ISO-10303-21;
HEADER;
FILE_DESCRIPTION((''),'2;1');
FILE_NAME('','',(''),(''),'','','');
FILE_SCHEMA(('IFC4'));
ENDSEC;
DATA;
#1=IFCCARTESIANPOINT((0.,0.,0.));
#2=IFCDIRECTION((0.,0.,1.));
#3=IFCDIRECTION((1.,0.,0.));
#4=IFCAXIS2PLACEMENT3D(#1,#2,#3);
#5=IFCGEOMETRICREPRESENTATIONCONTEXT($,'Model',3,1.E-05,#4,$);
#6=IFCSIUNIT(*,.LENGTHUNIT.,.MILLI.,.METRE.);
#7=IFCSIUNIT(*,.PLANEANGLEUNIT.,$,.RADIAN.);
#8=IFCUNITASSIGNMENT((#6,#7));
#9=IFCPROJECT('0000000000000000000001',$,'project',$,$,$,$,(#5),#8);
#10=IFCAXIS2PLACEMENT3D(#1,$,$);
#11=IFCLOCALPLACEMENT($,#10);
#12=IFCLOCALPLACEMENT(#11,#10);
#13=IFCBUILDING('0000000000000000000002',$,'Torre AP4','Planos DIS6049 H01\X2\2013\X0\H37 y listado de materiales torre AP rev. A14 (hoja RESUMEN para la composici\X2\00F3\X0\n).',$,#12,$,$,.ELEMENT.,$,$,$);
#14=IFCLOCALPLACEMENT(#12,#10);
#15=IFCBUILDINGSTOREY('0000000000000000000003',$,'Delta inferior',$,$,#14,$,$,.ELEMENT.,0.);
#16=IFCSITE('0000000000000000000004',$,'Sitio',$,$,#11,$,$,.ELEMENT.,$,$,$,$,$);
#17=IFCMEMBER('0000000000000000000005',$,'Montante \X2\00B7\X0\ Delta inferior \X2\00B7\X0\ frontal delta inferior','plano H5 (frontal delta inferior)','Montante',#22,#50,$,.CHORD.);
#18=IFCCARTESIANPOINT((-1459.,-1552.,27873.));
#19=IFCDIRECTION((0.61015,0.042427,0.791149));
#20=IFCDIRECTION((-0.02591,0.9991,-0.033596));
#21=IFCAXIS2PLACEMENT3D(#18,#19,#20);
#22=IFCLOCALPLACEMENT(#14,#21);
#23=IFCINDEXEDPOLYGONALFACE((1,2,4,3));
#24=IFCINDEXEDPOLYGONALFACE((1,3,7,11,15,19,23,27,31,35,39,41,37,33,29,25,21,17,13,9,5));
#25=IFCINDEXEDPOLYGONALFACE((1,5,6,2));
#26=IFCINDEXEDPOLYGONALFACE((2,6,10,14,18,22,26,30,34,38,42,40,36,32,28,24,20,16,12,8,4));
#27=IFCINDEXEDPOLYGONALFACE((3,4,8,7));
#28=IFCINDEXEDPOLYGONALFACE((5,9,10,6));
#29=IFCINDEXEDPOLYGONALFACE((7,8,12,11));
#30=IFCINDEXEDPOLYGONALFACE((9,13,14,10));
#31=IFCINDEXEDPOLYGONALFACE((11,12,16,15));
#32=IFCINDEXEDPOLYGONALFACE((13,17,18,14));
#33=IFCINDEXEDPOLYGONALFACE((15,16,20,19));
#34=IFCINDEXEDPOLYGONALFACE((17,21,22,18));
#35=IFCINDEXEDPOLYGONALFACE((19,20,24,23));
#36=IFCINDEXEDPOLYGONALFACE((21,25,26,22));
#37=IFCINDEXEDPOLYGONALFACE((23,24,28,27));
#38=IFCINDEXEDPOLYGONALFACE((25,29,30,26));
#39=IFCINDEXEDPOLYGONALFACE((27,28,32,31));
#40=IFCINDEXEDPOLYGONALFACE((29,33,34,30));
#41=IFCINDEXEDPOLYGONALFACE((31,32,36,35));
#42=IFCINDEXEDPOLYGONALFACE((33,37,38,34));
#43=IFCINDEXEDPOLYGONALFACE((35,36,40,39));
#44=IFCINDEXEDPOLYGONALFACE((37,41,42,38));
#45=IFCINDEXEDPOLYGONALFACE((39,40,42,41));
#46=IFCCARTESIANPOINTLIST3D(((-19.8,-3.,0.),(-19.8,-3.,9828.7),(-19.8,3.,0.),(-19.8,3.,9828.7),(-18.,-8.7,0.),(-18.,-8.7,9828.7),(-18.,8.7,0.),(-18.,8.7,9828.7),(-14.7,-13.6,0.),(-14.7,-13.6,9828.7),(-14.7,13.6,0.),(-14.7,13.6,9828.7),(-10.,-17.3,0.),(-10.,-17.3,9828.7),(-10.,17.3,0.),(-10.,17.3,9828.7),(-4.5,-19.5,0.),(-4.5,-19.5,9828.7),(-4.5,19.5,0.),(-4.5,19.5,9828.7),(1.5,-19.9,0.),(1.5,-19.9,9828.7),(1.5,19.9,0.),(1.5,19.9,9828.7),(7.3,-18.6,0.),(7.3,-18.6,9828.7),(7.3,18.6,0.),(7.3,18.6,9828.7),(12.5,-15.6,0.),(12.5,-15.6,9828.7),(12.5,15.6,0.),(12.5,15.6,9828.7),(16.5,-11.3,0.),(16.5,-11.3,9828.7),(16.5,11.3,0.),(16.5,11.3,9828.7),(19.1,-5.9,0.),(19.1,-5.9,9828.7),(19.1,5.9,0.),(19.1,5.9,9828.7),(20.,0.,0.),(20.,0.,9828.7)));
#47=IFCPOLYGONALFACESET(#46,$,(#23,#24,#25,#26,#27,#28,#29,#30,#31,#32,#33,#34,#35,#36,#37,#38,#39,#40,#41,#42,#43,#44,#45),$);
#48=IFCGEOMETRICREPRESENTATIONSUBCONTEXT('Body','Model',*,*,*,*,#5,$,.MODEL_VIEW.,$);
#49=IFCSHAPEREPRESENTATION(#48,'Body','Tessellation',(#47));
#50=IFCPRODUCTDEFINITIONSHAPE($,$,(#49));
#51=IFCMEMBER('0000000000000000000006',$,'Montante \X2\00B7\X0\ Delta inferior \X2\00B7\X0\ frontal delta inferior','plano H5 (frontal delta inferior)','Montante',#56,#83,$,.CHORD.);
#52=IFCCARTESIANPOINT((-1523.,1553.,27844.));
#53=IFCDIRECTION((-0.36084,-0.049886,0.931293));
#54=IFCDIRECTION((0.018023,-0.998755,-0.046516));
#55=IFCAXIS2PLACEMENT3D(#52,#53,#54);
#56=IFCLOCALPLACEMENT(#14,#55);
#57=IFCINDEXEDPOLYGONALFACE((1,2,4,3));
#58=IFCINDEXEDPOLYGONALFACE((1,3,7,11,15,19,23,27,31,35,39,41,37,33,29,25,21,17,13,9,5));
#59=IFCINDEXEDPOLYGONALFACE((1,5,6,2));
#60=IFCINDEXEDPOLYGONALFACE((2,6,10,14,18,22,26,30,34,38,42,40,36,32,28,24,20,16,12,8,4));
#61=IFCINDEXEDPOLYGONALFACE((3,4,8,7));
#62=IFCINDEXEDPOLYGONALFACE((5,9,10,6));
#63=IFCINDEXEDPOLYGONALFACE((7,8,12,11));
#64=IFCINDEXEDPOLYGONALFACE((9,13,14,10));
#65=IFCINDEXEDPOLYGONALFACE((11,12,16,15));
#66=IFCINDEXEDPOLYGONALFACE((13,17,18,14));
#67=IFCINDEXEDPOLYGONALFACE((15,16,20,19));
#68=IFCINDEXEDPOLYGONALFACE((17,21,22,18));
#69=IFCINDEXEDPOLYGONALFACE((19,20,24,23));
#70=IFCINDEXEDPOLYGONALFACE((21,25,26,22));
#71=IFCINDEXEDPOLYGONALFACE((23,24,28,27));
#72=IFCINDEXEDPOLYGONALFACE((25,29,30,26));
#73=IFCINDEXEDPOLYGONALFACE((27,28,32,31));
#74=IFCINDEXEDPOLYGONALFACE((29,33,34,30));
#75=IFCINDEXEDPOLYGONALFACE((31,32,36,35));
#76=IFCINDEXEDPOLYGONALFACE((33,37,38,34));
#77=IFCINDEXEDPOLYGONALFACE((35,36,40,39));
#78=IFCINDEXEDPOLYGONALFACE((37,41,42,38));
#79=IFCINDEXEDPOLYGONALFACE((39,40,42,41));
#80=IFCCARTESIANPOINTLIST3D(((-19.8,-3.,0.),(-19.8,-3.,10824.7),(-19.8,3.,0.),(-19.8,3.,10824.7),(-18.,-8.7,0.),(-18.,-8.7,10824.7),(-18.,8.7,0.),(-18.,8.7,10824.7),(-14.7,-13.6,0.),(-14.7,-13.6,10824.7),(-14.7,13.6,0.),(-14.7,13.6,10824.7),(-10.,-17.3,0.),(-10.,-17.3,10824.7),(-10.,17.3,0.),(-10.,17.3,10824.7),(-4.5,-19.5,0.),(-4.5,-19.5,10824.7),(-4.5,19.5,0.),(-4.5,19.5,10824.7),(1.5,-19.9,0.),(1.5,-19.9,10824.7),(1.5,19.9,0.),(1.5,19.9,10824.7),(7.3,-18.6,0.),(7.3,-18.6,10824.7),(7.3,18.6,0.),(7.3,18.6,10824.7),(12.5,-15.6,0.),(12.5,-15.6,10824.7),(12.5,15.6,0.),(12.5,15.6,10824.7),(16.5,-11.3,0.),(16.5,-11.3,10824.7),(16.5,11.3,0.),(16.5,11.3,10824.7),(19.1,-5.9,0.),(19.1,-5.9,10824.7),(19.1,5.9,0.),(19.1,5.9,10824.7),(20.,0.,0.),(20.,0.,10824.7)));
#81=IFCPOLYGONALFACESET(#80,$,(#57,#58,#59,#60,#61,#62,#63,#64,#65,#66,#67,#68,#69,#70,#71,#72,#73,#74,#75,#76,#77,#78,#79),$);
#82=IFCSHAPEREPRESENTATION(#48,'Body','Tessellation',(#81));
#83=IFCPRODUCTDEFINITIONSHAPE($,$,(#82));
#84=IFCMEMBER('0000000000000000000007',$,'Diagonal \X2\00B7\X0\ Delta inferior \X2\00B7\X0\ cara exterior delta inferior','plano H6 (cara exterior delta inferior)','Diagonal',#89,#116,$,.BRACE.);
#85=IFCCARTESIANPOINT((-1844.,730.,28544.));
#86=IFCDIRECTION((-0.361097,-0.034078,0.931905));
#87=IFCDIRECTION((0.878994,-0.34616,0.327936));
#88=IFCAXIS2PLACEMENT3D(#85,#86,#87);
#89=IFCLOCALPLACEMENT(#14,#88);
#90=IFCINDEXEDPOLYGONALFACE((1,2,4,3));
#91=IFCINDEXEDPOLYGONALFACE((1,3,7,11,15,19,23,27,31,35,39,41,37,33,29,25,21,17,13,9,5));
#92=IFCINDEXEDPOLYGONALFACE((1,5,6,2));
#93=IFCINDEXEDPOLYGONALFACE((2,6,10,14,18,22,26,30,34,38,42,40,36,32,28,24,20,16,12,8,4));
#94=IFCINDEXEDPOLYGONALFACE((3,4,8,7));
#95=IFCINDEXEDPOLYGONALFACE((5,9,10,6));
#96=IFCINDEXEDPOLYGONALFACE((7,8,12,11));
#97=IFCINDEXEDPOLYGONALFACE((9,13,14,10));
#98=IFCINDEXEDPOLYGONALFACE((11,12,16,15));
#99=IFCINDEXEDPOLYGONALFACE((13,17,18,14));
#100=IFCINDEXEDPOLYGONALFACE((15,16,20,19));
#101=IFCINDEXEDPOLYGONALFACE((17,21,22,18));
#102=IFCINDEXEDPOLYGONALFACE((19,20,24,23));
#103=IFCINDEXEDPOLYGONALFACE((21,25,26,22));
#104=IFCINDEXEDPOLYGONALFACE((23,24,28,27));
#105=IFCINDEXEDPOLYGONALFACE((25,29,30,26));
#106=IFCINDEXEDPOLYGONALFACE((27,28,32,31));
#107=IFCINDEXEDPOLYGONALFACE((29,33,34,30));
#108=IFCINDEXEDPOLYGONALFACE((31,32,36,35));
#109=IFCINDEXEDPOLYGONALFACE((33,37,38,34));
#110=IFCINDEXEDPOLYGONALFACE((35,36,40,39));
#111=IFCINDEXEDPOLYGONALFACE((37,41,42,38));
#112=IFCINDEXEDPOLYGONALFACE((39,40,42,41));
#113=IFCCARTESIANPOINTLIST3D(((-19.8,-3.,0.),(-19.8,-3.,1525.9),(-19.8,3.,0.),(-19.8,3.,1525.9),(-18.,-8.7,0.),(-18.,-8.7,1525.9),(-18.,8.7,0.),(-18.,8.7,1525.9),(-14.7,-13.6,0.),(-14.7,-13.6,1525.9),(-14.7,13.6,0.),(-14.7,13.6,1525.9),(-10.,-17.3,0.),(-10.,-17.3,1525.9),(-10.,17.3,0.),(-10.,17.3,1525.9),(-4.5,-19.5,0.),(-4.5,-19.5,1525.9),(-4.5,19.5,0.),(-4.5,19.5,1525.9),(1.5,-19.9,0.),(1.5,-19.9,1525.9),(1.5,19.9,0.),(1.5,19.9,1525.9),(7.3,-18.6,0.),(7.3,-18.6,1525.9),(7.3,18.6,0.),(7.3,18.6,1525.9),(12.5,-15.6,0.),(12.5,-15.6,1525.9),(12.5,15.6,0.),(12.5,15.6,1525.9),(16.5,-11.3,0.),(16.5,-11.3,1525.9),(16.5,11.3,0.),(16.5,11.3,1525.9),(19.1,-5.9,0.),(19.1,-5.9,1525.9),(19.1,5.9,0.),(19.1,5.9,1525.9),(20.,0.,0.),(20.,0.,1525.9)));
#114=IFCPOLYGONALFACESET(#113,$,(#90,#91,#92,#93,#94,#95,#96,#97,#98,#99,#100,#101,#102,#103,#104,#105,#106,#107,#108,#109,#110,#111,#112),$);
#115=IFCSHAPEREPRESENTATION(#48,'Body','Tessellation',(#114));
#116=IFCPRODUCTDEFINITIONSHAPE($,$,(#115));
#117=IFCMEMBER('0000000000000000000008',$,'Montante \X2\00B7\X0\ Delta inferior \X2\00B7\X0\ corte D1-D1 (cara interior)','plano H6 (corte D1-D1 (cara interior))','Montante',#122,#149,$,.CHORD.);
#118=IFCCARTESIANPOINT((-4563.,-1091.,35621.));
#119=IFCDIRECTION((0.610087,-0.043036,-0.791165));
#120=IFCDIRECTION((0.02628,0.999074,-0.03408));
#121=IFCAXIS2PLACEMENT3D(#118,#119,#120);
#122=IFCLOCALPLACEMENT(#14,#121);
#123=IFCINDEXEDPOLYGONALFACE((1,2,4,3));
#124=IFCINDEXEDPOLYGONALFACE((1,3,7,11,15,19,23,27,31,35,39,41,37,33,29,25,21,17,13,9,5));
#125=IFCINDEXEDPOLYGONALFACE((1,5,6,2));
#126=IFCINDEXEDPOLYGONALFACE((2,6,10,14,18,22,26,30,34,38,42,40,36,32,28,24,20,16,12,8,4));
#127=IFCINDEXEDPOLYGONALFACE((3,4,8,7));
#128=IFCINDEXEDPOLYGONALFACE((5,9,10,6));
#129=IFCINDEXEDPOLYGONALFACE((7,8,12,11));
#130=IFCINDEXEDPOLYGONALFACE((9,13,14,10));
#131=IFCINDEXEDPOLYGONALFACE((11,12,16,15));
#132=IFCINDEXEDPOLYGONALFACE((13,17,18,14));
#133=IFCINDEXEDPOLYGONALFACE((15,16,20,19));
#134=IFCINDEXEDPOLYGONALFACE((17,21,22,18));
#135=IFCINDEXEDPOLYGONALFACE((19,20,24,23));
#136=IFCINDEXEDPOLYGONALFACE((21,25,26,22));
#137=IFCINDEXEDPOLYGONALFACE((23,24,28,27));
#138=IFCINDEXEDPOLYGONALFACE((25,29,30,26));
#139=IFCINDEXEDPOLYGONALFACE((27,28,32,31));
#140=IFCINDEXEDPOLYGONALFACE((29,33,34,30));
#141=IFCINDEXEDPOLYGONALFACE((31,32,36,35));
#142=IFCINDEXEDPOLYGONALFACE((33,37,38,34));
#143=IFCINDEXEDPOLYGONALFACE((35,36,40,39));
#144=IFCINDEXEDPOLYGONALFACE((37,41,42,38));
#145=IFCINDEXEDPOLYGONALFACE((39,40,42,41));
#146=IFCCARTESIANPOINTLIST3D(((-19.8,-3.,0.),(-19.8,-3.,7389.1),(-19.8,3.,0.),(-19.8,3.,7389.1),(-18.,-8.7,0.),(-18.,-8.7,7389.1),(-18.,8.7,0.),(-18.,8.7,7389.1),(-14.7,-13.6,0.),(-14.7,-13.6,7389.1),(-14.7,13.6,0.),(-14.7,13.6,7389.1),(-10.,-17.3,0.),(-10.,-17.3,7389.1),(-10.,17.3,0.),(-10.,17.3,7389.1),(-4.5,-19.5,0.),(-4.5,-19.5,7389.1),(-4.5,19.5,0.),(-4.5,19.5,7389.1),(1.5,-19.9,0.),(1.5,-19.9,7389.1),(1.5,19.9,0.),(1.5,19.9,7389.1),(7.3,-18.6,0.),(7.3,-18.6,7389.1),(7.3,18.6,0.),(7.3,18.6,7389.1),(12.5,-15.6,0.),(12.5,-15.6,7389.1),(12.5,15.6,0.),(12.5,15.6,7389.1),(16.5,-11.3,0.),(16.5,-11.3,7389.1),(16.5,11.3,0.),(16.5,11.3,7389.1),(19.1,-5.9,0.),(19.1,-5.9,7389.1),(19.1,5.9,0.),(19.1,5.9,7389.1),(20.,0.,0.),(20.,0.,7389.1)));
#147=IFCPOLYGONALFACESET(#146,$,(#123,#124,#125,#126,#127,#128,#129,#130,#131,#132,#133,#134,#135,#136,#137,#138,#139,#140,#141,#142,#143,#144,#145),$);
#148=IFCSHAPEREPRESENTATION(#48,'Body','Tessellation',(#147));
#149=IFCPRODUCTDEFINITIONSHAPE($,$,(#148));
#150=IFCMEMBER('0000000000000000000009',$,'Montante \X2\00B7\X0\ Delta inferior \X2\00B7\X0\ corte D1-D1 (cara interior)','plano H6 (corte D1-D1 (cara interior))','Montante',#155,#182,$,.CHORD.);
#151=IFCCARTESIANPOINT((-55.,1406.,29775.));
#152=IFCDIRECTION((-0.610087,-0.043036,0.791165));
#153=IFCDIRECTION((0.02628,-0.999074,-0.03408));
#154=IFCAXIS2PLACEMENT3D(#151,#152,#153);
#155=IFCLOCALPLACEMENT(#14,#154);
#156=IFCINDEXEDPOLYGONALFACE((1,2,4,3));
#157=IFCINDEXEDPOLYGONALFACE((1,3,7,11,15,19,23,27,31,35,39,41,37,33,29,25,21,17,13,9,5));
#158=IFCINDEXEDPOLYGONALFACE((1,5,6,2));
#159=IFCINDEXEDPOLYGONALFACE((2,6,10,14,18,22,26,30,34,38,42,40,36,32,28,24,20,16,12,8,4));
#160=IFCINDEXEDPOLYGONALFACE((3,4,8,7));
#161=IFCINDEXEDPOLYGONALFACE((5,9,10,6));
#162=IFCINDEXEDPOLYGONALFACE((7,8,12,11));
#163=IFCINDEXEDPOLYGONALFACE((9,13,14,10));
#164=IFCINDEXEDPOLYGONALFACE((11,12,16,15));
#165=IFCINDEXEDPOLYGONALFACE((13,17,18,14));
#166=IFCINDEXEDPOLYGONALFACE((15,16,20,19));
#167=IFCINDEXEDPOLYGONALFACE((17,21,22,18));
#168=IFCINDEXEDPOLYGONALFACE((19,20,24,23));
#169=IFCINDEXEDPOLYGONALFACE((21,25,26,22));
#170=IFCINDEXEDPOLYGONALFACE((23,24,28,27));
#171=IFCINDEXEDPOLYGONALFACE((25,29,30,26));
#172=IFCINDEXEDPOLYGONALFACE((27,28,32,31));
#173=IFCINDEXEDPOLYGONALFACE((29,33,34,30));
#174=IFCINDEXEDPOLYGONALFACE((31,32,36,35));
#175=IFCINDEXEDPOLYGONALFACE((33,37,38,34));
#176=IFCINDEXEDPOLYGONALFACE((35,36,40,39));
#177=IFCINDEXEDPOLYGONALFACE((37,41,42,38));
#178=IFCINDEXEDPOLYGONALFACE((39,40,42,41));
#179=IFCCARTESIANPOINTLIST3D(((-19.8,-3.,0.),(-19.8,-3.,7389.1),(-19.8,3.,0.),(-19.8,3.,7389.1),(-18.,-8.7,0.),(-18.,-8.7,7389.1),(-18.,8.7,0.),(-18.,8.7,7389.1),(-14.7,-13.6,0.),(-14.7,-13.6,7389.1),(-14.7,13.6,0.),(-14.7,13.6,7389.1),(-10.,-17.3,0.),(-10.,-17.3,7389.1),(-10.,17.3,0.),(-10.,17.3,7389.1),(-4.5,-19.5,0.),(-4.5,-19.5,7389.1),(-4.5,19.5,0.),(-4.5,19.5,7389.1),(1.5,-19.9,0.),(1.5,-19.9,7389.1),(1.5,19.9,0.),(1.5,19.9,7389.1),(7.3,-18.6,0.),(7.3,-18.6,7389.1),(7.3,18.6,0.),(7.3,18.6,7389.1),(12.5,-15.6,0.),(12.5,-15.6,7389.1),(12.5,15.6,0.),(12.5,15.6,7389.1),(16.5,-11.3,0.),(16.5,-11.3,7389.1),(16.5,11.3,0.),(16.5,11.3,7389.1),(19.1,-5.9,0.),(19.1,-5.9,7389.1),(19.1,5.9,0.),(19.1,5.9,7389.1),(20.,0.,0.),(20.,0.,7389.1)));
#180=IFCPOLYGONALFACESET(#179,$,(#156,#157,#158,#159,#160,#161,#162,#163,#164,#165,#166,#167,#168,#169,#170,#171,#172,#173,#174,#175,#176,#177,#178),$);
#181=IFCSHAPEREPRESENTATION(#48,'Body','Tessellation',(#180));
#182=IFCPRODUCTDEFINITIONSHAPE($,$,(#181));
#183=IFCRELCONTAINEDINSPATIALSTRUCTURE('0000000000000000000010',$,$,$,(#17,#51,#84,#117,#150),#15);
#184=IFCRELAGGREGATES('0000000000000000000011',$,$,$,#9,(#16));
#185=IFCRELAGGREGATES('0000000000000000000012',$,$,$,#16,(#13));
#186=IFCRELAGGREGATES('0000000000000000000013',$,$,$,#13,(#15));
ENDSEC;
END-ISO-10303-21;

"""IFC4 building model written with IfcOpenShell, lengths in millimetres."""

from ifc_helpers import new_model, si_unit, frame, origin, origin_with_axes, place, context, subcontext, project, spatial, circle, extrude, element, save


model = new_model("IFC4")

# Units and contexts
model_context = context("Model", 3, precision=1e-05, world=origin_with_axes())
body_context = subcontext(model_context, "Body", "Model", "MODEL_VIEW")
ifc_project = project(units=[si_unit("LENGTHUNIT", "METRE", prefix="MILLI"), si_unit("PLANEANGLEUNIT", "RADIAN")], contexts=[model_context])

# Site, building, storey
site_placement = place(None, origin())
site = spatial("IfcSite", under=ifc_project, at=site_placement, Name="Sitio", CompositionType="ELEMENT")
building_placement = place(site_placement, origin())
building = spatial("IfcBuilding", under=site, at=building_placement, Name="Torre AP4", Description="Planos DIS6049 H01–H37 y listado de materiales torre AP rev. A14 (hoja RESUMEN para la composición).", CompositionType="ELEMENT")
storey_placement = place(building_placement, origin())
storey = spatial("IfcBuildingStorey", under=building, at=storey_placement, Name="Delta inferior", CompositionType="ELEMENT", Elevation=0.0)

# Members
for number, where, z_axis, x_axis, name in (
    (1, (-1459.0, -1552.0, 27873.0), (0.61015, 0.042427, 0.791149), (-0.02591, 0.9991, -0.033596), "Montante · Delta inferior · frontal delta inferior"),
):
    element("IfcMember", number, at=place(storey_placement, frame(where, z_axis=z_axis, x_axis=x_axis)), inside=storey, Name=name, Description="plano H5 (frontal delta inferior)", ObjectType="Montante", PredefinedType="CHORD", context=body_context, shape_type="SweptSolid", body=[
        extrude(circle(Radius=20.0), None, (0.0, 0.0, 1.0), 9828.7),
    ])
for number, where, z_axis, x_axis, name in (
    (2, (-1523.0, 1553.0, 27844.0), (-0.36084, -0.049886, 0.931293), (0.018023, -0.998755, -0.046516), "Montante · Delta inferior · frontal delta inferior"),
):
    element("IfcMember", number, at=place(storey_placement, frame(where, z_axis=z_axis, x_axis=x_axis)), inside=storey, Name=name, Description="plano H5 (frontal delta inferior)", ObjectType="Montante", PredefinedType="CHORD", context=body_context, shape_type="SweptSolid", body=[
        extrude(circle(Radius=20.0), None, (0.0, 0.0, 1.0), 10824.7),
    ])
member_1_placement = place(storey_placement, frame((-1844.0, 730.0, 28544.0), z_axis=(-0.361097, -0.034078, 0.931905), x_axis=(0.878994, -0.34616, 0.327936)))
element("IfcMember", 3, at=member_1_placement, inside=storey, Name="Diagonal · Delta inferior · cara exterior delta inferior", Description="plano H6 (cara exterior delta inferior)", ObjectType="Diagonal", PredefinedType="BRACE", context=body_context, shape_type="SweptSolid", body=[
    extrude(circle(Radius=20.0), None, (0.0, 0.0, 1.0), 1525.9),
])
member_2_placement = place(storey_placement, frame((-4563.0, -1091.0, 35621.0), z_axis=(0.610087, -0.043036, -0.791165), x_axis=(0.02628, 0.999074, -0.03408)))
element("IfcMember", 4, at=member_2_placement, inside=storey, Name="Montante · Delta inferior · corte D1-D1 (cara interior)", Description="plano H6 (corte D1-D1 (cara interior))", ObjectType="Montante", PredefinedType="CHORD", context=body_context, shape_type="SweptSolid", body=[
    extrude(circle(Radius=20.0), None, (0.0, 0.0, 1.0), 7389.1),
])
for number, where, z_axis, x_axis, name in (
    (5, (-55.0, 1406.0, 29775.0), (-0.610087, -0.043036, 0.791165), (0.02628, -0.999074, -0.03408), "Montante · Delta inferior · corte D1-D1 (cara interior)"),
):
    element("IfcMember", number, at=place(storey_placement, frame(where, z_axis=z_axis, x_axis=x_axis)), inside=storey, Name=name, Description="plano H6 (corte D1-D1 (cara interior))", ObjectType="Montante", PredefinedType="CHORD", context=body_context, shape_type="SweptSolid", body=[
        extrude(circle(Radius=20.0), None, (0.0, 0.0, 1.0), 7389.1),
    ])

save(model, "model.ifc")
